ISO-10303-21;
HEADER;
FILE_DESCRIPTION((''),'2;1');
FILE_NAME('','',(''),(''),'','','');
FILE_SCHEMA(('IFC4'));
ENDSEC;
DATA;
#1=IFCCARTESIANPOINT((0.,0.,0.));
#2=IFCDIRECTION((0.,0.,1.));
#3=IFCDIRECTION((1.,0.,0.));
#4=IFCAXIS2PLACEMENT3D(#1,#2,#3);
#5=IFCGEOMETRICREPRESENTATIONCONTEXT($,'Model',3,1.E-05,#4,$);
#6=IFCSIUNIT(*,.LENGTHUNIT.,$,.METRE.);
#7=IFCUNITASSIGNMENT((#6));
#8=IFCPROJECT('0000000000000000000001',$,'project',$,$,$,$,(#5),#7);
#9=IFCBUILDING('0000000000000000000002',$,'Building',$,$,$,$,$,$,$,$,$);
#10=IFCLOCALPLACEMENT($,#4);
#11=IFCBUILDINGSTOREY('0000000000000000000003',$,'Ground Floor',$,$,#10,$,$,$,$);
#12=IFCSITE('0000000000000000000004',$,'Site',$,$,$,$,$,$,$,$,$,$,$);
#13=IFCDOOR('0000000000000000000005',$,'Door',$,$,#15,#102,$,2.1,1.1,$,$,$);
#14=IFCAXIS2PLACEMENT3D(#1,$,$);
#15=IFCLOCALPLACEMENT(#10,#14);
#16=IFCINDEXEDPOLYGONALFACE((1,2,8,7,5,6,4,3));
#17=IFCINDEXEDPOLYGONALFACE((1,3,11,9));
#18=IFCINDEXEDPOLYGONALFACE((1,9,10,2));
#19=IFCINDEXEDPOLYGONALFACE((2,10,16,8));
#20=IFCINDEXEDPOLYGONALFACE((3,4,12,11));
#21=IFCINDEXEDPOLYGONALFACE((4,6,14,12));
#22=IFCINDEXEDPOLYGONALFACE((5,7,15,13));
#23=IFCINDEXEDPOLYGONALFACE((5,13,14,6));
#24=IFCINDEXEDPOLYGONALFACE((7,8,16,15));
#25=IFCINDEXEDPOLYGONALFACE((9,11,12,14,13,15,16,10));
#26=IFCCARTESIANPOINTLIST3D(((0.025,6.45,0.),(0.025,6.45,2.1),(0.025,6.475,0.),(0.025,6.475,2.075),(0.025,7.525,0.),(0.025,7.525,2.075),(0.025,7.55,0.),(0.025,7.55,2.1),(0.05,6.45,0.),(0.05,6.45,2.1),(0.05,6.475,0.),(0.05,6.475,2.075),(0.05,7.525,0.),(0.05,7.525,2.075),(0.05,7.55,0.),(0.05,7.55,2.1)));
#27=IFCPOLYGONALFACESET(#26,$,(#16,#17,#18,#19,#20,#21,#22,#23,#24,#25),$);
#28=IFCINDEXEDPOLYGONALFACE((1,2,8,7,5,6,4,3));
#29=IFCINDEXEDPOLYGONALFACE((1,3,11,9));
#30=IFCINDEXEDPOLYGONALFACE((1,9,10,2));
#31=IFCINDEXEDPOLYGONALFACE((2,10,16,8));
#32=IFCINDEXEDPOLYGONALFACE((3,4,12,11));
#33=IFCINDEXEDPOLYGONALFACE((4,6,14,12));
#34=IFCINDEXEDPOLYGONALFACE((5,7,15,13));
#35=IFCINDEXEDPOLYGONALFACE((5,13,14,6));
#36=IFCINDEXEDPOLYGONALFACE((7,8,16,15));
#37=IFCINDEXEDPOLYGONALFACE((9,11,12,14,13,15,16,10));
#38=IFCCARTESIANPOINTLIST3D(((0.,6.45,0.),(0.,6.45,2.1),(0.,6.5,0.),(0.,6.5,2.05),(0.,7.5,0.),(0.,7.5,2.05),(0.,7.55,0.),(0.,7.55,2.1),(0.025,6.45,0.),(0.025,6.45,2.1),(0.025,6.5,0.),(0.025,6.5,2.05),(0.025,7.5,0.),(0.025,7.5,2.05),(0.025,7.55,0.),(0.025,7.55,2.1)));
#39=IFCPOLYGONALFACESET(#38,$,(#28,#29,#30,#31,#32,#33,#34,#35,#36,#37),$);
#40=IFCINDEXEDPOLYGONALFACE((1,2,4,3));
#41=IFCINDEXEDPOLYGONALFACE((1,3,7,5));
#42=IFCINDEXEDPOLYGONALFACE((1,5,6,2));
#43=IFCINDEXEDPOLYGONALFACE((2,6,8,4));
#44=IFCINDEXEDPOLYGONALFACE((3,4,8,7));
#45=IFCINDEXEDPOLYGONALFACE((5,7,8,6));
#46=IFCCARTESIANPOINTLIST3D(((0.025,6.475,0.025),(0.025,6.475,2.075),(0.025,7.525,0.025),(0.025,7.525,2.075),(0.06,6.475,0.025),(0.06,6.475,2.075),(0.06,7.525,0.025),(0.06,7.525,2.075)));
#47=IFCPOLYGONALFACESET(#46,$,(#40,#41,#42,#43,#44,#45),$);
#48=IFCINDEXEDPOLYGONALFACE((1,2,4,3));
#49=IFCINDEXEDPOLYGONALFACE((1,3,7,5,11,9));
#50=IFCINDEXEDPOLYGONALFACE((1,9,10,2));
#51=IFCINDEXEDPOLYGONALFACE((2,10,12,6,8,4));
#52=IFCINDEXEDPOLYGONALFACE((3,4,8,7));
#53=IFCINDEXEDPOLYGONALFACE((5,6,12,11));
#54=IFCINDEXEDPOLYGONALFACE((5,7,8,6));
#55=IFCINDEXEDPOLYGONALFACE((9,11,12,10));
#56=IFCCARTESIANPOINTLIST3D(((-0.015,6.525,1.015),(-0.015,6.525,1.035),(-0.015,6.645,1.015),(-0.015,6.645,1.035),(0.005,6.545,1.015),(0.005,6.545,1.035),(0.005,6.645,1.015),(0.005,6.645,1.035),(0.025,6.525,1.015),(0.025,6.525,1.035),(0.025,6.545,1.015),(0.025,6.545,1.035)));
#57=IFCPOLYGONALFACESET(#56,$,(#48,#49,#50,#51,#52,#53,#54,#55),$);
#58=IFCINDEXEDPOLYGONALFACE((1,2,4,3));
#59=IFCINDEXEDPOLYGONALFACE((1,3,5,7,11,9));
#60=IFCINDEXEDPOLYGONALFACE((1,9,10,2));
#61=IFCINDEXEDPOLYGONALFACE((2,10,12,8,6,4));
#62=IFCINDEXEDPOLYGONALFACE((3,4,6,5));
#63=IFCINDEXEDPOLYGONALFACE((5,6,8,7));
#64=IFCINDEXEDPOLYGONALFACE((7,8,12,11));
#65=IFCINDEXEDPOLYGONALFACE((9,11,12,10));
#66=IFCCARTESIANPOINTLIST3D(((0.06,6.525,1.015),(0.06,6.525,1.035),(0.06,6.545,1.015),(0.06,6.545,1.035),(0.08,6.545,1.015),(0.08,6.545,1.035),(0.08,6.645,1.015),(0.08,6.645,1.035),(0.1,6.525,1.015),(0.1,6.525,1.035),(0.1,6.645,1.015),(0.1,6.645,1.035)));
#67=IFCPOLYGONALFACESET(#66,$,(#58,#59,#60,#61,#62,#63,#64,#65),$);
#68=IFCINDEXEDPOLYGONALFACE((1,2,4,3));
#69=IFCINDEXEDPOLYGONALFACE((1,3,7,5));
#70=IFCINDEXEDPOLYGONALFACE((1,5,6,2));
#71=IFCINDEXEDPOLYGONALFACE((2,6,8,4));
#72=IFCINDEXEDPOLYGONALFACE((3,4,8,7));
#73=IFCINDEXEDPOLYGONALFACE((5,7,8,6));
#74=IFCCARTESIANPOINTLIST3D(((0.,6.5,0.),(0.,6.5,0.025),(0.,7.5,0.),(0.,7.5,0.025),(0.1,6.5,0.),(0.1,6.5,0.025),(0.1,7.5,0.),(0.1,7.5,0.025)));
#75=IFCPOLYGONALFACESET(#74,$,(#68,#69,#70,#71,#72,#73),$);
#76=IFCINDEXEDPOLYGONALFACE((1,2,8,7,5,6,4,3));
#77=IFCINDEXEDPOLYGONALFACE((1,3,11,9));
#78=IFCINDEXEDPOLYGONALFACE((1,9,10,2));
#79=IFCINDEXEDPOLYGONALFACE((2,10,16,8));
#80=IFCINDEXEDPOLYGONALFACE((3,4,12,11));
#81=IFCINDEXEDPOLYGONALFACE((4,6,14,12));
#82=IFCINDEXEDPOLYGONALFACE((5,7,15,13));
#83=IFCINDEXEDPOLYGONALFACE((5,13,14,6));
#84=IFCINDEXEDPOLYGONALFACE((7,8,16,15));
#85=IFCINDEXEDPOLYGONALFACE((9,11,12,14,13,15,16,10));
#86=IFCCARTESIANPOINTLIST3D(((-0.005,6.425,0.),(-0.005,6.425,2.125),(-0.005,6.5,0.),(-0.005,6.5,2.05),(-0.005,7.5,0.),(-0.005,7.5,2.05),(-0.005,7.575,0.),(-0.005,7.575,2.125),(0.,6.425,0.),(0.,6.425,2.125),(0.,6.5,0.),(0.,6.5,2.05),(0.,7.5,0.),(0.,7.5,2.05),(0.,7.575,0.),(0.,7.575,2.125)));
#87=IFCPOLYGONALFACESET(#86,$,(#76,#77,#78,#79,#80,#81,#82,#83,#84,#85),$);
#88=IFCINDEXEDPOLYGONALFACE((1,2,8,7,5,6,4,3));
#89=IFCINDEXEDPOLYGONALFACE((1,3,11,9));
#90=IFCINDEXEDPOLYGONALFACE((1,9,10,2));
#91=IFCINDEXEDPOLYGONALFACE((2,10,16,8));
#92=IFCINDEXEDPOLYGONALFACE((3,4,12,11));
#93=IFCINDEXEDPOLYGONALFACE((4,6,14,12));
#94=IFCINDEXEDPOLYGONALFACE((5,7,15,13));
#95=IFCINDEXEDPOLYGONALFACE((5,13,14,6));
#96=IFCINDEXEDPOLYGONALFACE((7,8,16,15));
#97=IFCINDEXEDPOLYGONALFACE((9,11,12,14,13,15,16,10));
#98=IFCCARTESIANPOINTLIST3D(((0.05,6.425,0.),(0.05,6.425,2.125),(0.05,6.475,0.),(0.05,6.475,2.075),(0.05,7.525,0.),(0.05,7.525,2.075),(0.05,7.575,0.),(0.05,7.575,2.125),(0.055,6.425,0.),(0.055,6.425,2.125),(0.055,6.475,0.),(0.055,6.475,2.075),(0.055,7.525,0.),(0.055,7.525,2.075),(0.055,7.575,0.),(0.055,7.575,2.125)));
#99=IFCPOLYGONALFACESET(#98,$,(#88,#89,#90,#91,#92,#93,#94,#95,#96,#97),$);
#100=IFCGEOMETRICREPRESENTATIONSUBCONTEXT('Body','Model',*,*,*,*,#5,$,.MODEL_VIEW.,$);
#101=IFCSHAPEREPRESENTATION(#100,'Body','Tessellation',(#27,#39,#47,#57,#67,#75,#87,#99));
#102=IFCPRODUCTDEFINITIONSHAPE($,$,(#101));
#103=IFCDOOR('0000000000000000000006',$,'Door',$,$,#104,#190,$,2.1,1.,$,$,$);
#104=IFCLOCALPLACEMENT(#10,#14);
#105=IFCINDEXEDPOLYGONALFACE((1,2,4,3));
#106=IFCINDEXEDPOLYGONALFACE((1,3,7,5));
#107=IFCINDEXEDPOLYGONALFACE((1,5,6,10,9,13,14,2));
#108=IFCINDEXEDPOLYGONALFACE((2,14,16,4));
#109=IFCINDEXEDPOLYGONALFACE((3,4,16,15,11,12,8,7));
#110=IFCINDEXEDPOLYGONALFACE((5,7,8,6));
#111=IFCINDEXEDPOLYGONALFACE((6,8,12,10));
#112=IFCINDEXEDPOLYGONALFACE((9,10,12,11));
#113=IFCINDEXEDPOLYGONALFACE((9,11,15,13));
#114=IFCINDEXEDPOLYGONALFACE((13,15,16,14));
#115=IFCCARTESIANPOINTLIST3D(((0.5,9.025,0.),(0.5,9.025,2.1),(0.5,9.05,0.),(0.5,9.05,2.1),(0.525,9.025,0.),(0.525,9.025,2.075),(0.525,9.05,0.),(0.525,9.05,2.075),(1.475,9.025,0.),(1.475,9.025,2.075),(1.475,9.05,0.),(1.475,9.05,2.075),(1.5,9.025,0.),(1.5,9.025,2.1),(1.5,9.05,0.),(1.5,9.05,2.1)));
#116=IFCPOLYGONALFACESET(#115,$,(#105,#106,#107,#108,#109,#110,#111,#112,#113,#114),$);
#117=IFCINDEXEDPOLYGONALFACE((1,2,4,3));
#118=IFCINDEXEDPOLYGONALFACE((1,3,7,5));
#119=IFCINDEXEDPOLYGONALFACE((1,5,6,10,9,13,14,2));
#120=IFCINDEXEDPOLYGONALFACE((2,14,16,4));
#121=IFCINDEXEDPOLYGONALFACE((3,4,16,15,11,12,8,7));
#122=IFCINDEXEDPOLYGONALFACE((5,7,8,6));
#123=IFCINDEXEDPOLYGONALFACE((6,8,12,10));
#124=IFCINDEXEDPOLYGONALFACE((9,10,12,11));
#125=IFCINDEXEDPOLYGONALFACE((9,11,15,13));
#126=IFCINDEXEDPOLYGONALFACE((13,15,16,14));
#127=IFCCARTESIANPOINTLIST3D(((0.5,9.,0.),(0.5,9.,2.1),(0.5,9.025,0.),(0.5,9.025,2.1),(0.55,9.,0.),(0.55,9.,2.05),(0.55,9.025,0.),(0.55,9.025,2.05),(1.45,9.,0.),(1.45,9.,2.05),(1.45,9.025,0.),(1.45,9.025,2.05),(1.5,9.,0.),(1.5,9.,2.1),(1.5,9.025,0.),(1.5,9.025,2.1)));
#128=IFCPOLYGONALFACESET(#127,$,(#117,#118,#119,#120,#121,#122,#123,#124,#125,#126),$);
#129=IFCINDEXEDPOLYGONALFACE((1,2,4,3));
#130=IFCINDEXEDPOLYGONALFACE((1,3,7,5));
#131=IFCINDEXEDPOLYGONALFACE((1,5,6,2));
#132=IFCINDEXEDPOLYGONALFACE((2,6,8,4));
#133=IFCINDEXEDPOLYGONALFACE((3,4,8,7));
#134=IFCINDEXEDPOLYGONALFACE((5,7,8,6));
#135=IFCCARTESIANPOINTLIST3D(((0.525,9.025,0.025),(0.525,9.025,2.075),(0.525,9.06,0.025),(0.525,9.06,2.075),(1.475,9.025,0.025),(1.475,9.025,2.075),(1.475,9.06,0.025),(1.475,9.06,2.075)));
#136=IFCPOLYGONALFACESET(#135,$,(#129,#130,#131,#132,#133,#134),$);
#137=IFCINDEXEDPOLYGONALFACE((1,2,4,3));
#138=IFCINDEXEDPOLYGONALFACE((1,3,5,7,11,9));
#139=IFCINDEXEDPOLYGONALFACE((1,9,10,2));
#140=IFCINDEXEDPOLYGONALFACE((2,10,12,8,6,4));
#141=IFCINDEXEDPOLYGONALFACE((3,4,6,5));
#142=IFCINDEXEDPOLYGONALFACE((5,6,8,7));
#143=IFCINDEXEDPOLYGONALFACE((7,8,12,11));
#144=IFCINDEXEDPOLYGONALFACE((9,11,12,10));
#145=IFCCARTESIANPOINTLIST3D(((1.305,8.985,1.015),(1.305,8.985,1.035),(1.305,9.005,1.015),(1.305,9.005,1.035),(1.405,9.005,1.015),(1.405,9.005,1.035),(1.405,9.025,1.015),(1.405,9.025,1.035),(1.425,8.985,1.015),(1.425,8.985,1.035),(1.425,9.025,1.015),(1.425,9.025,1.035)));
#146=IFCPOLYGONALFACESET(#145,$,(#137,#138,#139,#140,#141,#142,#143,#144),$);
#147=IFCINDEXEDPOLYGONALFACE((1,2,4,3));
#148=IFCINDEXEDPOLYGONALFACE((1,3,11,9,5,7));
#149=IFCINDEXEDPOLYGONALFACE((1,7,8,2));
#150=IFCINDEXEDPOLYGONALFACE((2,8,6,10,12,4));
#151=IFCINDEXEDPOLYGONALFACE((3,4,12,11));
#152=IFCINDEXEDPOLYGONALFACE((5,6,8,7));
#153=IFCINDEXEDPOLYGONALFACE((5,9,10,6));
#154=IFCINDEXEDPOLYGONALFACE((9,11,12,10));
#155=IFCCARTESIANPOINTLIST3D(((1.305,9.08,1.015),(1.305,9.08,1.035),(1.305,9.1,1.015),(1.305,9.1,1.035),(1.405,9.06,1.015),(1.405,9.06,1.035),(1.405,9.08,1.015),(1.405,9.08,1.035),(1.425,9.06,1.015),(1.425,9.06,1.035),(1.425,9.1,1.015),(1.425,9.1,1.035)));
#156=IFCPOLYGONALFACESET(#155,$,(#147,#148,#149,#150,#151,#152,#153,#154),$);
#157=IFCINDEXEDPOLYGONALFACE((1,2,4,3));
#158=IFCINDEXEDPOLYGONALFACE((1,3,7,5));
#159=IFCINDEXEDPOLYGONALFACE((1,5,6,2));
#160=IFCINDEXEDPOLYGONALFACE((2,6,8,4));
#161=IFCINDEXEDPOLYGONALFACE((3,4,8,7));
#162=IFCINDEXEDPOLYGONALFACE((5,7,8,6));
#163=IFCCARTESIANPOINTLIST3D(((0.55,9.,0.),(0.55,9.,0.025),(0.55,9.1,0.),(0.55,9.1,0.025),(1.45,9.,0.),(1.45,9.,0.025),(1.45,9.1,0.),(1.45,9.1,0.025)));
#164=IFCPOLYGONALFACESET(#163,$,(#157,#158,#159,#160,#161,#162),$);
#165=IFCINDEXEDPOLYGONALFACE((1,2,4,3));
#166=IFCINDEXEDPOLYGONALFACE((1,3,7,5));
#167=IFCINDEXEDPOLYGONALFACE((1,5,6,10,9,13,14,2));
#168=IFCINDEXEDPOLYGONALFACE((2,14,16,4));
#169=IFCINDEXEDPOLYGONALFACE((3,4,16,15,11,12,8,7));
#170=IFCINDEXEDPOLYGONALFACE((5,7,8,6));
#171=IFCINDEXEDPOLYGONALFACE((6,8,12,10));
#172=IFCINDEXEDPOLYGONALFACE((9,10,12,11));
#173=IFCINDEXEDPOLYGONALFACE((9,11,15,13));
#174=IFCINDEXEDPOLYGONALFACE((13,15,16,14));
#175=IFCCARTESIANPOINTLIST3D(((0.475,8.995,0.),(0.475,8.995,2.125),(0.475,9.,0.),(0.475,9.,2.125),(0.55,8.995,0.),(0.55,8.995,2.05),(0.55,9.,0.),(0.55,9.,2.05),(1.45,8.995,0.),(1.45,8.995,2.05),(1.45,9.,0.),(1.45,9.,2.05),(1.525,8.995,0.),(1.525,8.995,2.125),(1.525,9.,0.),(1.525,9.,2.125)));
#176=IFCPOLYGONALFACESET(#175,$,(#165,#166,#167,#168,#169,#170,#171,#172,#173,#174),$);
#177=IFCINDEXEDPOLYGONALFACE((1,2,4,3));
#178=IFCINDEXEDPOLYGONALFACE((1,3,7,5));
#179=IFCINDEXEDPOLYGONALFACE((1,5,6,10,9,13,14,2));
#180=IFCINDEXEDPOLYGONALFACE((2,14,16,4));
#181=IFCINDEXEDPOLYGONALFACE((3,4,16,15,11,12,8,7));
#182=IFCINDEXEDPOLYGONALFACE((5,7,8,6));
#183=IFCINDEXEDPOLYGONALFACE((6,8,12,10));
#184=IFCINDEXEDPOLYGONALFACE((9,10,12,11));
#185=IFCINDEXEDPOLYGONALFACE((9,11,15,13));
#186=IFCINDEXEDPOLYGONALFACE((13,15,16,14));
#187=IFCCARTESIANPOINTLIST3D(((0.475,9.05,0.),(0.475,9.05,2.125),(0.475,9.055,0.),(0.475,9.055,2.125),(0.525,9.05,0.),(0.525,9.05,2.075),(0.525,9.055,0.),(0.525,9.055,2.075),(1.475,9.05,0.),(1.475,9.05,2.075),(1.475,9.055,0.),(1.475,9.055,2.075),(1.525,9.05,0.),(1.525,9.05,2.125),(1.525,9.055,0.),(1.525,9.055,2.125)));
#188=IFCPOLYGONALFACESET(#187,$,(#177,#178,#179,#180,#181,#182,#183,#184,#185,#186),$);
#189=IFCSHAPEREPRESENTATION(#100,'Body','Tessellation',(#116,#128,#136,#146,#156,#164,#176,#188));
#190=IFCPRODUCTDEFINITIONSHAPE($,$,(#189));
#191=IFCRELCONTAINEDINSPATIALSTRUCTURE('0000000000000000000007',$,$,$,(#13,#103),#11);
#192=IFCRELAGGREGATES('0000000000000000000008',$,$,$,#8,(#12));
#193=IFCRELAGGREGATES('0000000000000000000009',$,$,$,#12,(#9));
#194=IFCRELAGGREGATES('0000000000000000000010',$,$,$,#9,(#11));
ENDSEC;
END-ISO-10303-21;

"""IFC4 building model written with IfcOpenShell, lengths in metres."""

from ifc_helpers import new_model, si_unit, frame, origin_with_axes, place, context, subcontext, project, spatial, line, indexed_curve, outline, extrude, element, save


model = new_model("IFC4")

# Units and contexts
model_context = context("Model", 3, precision=1e-05, world=origin_with_axes())
body_context = subcontext(model_context, "Body", "Model", "MODEL_VIEW")
ifc_project = project(units=[si_unit("LENGTHUNIT", "METRE")], contexts=[model_context])

# Site, building, storey
site = spatial("IfcSite", under=ifc_project, Name="Site")
building = spatial("IfcBuilding", under=site, Name="Building")
storey_placement = place(None, origin_with_axes())
storey = spatial("IfcBuildingStorey", under=building, at=storey_placement, Name="Ground Floor")

# Doors
door_1_placement = place(storey_placement, frame((0.0, 7.55, 0.0), z_axis=(0.0, 0.0, 1.0), x_axis=(0.0, -1.0, 0.0)))
element("IfcDoor", 1, at=door_1_placement, inside=storey, Name="Door", OverallHeight=2.1, OverallWidth=1.1, context=body_context, shape_type="SweptSolid", body=[
    extrude(outline(indexed_curve([(0.0, 0.0), (0.0, 2.1), (1.1, 2.1), (1.1, 0.0), (1.075, 0.0), (1.075, 2.075), (0.025, 2.075), (0.025, 0.0)], segments=[line(1, 2, 3, 4, 5, 6, 7, 8, 1)])), frame((0.0, 0.025, 0.0), z_axis=(0.0, -1.0, 0.0), x_axis=(1.0, 0.0, 0.0)), (0.0, 0.0, -1.0), 0.025),
    extrude(outline(indexed_curve([(0.0, 0.0), (0.0, 2.1), (1.1, 2.1), (1.1, 0.0), (1.05, 0.0), (1.05, 2.05), (0.05, 2.05), (0.05, 0.0)], segments=[line(1, 2, 3, 4, 5, 6, 7, 8, 1)])), frame((0.0, 0.0, 0.0), z_axis=(0.0, -1.0, 0.0), x_axis=(1.0, 0.0, 0.0)), (0.0, 0.0, -1.0), 0.025),
    extrude(outline(indexed_curve([(0.0, 0.0), (1.05, 0.0), (1.05, 0.035), (0.0, 0.035)], segments=[line(1, 2, 3, 4, 1)])), frame((0.025, 0.025, 0.025), z_axis=(0.0, 0.0, 1.0), x_axis=(1.0, 0.0, 0.0)), (0.0, 0.0, 1.0), 2.05),
    extrude(outline(indexed_curve([(0.0, 0.0), (0.0, -0.04), (-0.12, -0.04), (-0.12, -0.02), (-0.02, -0.02), (-0.02, 0.0)], segments=[line(1, 2, 3, 4, 5, 6, 1)])), frame((1.025, 0.025, 1.015), z_axis=(0.0, 0.0, 1.0), x_axis=(1.0, 0.0, 0.0)), (0.0, 0.0, 1.0), 0.02),
    extrude(outline(indexed_curve([(0.0, 0.0), (0.0, 0.04), (-0.12, 0.04), (-0.12, 0.02), (-0.02, 0.02), (-0.02, 0.0)], segments=[line(1, 2, 3, 4, 5, 6, 1)])), frame((1.025, 0.06, 1.015), z_axis=(0.0, 0.0, 1.0), x_axis=(1.0, 0.0, 0.0)), (0.0, 0.0, 1.0), 0.02),
    extrude(outline(indexed_curve([(0.0, 0.0), (1.0, 0.0), (1.0, 0.1), (0.0, 0.1)], segments=[line(1, 2, 3, 4, 1)])), frame((0.05, 0.0, 0.0), z_axis=(0.0, 0.0, 1.0), x_axis=(1.0, 0.0, 0.0)), (0.0, 0.0, 1.0), 0.025),
    extrude(outline(indexed_curve([(0.0, 0.0), (0.0, 2.125), (1.15, 2.125), (1.15, 0.0), (1.075, 0.0), (1.075, 2.05), (0.075, 2.05), (0.075, 0.0)], segments=[line(1, 2, 3, 4, 5, 6, 7, 8, 1)])), frame((-0.025, -0.005, 0.0), z_axis=(0.0, -1.0, 0.0), x_axis=(1.0, 0.0, 0.0)), (0.0, 0.0, -1.0), 0.005),
    extrude(outline(indexed_curve([(0.0, 0.0), (0.0, 2.125), (1.15, 2.125), (1.15, 0.0), (1.1, 0.0), (1.1, 2.075), (0.05, 2.075), (0.05, 0.0)], segments=[line(1, 2, 3, 4, 5, 6, 7, 8, 1)])), frame((-0.025, 0.05, 0.0), z_axis=(0.0, -1.0, 0.0), x_axis=(1.0, 0.0, 0.0)), (0.0, 0.0, -1.0), 0.005),
])
door_2_placement = place(storey_placement, frame((0.5, 9.0, 0.0), z_axis=(0.0, 0.0, 1.0), x_axis=(1.0, 0.0, 0.0)))
element("IfcDoor", 2, at=door_2_placement, inside=storey, Name="Door", OverallHeight=2.1, OverallWidth=1.0, context=body_context, shape_type="SweptSolid", body=[
    extrude(outline(indexed_curve([(0.0, 0.0), (0.0, 2.1), (1.0, 2.1), (1.0, 0.0), (0.975, 0.0), (0.975, 2.075), (0.025, 2.075), (0.025, 0.0)], segments=[line(1, 2, 3, 4, 5, 6, 7, 8, 1)])), frame((0.0, 0.025, 0.0), z_axis=(0.0, -1.0, 0.0), x_axis=(1.0, 0.0, 0.0)), (0.0, 0.0, -1.0), 0.025),
    extrude(outline(indexed_curve([(0.0, 0.0), (0.0, 2.1), (1.0, 2.1), (1.0, 0.0), (0.95, 0.0), (0.95, 2.05), (0.05, 2.05), (0.05, 0.0)], segments=[line(1, 2, 3, 4, 5, 6, 7, 8, 1)])), frame((0.0, 0.0, 0.0), z_axis=(0.0, -1.0, 0.0), x_axis=(1.0, 0.0, 0.0)), (0.0, 0.0, -1.0), 0.025),
    extrude(outline(indexed_curve([(0.0, 0.0), (0.95, 0.0), (0.95, 0.035), (0.0, 0.035)], segments=[line(1, 2, 3, 4, 1)])), frame((0.025, 0.025, 0.025), z_axis=(0.0, 0.0, 1.0), x_axis=(1.0, 0.0, 0.0)), (0.0, 0.0, 1.0), 2.05),
    extrude(outline(indexed_curve([(0.0, 0.0), (0.0, -0.04), (-0.12, -0.04), (-0.12, -0.02), (-0.02, -0.02), (-0.02, 0.0)], segments=[line(1, 2, 3, 4, 5, 6, 1)])), frame((0.925, 0.025, 1.015), z_axis=(0.0, 0.0, 1.0), x_axis=(1.0, 0.0, 0.0)), (0.0, 0.0, 1.0), 0.02),
    extrude(outline(indexed_curve([(0.0, 0.0), (0.0, 0.04), (-0.12, 0.04), (-0.12, 0.02), (-0.02, 0.02), (-0.02, 0.0)], segments=[line(1, 2, 3, 4, 5, 6, 1)])), frame((0.925, 0.06, 1.015), z_axis=(0.0, 0.0, 1.0), x_axis=(1.0, 0.0, 0.0)), (0.0, 0.0, 1.0), 0.02),
    extrude(outline(indexed_curve([(0.0, 0.0), (0.9, 0.0), (0.9, 0.1), (0.0, 0.1)], segments=[line(1, 2, 3, 4, 1)])), frame((0.05, 0.0, 0.0), z_axis=(0.0, 0.0, 1.0), x_axis=(1.0, 0.0, 0.0)), (0.0, 0.0, 1.0), 0.025),
    extrude(outline(indexed_curve([(0.0, 0.0), (0.0, 2.125), (1.05, 2.125), (1.05, 0.0), (0.975, 0.0), (0.975, 2.05), (0.075, 2.05), (0.075, 0.0)], segments=[line(1, 2, 3, 4, 5, 6, 7, 8, 1)])), frame((-0.025, -0.005, 0.0), z_axis=(0.0, -1.0, 0.0), x_axis=(1.0, 0.0, 0.0)), (0.0, 0.0, -1.0), 0.005),
    extrude(outline(indexed_curve([(0.0, 0.0), (0.0, 2.125), (1.05, 2.125), (1.05, 0.0), (1.0, 0.0), (1.0, 2.075), (0.05, 2.075), (0.05, 0.0)], segments=[line(1, 2, 3, 4, 5, 6, 7, 8, 1)])), frame((-0.025, 0.05, 0.0), z_axis=(0.0, -1.0, 0.0), x_axis=(1.0, 0.0, 0.0)), (0.0, 0.0, -1.0), 0.005),
])

save(model, "model.ifc")
